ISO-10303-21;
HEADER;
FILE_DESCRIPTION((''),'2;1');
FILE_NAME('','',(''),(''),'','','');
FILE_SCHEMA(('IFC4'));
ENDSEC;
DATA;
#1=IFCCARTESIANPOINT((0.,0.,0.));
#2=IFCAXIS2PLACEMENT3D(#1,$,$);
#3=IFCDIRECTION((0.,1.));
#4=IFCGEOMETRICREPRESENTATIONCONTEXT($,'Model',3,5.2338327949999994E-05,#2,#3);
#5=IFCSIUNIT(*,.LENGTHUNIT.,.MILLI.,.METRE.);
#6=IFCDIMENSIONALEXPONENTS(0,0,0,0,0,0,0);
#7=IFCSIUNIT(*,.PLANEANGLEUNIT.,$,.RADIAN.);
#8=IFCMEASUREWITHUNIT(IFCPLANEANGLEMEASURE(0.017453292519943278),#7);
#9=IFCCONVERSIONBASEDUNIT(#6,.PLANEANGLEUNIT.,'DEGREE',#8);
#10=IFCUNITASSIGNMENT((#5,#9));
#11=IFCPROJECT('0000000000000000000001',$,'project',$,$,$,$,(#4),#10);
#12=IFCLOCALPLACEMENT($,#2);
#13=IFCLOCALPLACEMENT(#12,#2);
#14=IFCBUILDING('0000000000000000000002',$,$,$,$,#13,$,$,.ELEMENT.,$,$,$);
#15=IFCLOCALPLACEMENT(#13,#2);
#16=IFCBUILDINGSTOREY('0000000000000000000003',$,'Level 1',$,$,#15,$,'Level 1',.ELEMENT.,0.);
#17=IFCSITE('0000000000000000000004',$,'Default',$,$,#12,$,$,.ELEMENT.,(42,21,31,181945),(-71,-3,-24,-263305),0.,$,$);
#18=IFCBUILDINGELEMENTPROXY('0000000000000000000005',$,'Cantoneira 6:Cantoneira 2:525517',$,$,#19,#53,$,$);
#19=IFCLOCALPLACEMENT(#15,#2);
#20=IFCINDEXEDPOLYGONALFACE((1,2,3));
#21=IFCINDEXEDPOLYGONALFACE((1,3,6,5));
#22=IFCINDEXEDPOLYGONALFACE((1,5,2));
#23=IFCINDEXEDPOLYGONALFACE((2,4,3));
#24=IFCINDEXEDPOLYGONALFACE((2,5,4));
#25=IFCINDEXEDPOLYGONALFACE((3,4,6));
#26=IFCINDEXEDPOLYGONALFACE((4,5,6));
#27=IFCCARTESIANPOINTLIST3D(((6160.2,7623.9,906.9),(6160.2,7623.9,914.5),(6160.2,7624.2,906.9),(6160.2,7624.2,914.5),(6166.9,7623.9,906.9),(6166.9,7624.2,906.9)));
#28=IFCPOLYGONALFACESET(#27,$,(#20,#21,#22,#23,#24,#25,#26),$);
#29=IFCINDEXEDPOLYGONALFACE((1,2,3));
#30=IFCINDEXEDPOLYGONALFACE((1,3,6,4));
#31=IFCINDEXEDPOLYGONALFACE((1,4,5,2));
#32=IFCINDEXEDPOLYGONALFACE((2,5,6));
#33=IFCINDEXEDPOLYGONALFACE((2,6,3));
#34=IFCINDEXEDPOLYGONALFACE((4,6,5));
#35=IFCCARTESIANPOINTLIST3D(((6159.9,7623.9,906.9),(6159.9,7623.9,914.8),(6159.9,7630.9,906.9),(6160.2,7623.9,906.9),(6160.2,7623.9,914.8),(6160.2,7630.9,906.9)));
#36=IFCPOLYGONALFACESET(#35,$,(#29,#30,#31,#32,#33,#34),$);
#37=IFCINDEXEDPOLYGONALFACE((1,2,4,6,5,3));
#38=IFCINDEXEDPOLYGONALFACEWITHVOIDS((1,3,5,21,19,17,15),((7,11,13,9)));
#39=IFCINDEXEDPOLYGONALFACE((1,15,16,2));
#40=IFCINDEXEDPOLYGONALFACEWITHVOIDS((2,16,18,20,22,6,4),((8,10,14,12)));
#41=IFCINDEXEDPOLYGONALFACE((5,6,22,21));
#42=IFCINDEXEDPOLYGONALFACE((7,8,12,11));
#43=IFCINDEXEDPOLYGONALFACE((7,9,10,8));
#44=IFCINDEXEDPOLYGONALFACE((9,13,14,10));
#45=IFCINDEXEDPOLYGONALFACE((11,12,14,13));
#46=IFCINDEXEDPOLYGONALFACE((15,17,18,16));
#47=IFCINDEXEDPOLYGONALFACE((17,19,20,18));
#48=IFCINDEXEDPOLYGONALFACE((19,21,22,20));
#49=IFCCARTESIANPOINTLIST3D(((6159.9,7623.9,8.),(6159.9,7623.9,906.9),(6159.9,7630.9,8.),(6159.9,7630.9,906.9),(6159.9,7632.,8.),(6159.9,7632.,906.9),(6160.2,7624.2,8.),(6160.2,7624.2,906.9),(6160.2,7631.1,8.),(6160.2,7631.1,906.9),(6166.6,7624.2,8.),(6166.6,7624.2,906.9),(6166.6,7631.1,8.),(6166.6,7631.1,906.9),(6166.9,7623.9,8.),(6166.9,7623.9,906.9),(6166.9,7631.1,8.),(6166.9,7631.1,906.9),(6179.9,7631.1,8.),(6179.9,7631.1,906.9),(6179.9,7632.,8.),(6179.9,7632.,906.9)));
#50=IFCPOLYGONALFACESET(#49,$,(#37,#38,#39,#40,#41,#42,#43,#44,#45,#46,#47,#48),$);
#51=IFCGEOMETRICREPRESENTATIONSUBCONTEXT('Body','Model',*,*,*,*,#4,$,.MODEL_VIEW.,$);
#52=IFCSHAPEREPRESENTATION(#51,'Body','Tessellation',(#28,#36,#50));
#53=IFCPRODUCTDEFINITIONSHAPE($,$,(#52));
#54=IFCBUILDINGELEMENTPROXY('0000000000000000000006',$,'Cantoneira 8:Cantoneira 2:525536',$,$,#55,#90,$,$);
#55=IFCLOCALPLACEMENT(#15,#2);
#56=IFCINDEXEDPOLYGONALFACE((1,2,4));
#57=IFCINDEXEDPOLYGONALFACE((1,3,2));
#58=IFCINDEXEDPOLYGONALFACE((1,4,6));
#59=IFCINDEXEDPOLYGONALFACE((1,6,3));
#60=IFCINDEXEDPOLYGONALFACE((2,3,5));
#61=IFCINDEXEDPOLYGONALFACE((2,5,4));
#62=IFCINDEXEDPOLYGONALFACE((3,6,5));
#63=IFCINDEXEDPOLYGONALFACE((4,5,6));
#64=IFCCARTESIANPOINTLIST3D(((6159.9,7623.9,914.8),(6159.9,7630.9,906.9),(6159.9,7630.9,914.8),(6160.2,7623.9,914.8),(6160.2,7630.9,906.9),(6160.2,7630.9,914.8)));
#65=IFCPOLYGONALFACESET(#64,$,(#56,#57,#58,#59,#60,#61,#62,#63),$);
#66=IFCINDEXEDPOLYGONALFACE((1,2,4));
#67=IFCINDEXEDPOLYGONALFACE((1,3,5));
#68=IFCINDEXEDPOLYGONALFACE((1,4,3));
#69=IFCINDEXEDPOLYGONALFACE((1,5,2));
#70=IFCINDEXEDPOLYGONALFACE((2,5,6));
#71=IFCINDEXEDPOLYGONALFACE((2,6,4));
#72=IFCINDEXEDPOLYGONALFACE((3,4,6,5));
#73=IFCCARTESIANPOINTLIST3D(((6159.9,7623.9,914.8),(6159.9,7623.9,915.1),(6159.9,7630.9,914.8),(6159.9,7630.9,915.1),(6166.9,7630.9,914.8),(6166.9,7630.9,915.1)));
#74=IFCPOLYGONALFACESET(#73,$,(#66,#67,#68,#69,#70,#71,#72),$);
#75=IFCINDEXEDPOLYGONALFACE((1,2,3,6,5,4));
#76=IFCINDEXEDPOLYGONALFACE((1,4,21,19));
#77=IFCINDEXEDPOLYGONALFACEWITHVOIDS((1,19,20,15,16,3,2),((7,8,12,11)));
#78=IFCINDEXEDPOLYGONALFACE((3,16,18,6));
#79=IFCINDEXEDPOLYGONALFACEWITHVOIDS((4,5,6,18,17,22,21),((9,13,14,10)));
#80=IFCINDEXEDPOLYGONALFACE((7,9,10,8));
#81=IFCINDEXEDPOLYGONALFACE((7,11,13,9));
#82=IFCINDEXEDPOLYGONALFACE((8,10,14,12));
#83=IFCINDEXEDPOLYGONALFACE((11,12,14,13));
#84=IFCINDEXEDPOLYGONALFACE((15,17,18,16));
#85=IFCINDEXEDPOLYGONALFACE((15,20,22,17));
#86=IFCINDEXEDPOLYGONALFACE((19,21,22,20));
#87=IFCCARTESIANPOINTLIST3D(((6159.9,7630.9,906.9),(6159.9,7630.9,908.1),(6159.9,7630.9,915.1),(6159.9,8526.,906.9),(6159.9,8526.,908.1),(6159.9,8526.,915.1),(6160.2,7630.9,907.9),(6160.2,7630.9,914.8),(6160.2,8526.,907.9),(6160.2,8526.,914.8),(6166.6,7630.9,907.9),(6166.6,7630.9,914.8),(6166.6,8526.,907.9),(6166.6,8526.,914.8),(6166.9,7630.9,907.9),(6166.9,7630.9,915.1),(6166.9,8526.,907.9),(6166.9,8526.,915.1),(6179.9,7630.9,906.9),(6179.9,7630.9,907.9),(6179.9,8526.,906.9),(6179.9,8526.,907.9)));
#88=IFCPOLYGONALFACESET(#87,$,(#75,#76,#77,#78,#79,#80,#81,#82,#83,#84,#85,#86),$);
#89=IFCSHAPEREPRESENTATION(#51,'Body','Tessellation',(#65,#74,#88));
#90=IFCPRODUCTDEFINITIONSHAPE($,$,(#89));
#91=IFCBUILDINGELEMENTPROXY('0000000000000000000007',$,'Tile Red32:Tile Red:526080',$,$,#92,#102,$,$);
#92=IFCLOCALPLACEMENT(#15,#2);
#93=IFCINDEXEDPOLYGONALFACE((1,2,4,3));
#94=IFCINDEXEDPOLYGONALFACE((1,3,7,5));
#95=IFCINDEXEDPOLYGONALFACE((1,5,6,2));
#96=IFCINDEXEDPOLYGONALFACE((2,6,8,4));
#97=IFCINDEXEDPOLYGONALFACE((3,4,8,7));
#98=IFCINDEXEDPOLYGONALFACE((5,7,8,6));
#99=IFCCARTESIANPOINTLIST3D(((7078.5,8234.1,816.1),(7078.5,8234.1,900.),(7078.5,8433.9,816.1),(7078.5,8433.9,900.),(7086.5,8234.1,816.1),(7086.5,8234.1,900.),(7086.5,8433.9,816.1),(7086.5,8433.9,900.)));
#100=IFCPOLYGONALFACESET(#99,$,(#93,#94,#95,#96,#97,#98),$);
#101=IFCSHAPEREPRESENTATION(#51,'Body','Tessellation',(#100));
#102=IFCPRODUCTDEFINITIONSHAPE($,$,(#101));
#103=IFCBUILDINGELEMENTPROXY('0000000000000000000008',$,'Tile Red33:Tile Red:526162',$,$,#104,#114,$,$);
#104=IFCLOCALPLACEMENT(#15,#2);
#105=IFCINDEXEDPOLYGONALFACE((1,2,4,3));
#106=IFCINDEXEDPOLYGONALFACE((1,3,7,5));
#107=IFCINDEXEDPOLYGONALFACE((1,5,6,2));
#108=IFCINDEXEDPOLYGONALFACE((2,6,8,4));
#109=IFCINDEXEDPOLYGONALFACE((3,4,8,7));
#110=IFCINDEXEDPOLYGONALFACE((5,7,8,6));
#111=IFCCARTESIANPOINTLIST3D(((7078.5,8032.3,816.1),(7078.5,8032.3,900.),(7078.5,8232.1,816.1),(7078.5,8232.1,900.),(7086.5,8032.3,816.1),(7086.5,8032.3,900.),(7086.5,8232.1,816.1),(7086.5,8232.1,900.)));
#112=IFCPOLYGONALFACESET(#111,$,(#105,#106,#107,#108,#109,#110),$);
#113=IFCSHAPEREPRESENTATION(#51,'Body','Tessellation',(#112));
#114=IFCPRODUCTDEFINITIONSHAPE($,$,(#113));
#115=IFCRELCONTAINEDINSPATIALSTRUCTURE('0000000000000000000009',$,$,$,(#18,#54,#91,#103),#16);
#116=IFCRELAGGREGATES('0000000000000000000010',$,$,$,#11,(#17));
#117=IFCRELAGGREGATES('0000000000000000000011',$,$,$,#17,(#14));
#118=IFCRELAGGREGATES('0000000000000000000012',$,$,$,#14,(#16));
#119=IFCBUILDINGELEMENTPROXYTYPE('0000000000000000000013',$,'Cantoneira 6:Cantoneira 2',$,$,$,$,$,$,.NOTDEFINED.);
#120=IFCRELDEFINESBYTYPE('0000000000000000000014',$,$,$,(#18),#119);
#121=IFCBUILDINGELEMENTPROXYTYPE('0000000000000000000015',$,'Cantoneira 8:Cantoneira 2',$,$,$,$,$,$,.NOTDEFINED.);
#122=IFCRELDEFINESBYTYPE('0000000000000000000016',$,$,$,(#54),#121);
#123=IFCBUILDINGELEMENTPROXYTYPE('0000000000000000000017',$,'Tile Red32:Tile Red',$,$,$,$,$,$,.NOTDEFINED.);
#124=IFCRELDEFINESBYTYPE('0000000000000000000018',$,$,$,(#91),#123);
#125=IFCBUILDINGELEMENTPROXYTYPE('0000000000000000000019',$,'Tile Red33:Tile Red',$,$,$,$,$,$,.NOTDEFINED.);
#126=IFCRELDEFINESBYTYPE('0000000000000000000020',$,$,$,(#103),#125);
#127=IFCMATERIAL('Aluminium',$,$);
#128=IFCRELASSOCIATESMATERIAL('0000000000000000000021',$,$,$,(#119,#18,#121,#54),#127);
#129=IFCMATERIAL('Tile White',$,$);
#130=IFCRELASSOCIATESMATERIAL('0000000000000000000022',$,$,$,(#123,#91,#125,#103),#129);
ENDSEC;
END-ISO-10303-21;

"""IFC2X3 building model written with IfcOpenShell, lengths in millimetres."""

from ifc_helpers import new_model, entity, si_unit, converted_unit, direction, frame, frame_2d, origin, place, context, subcontext, project, spatial, polyline, rectangle, outline, extrude, source, transform, mapped, material, type_object, type_shapes, element, save


model = new_model("IFC2X3")

# Units and contexts
model_context = context("Model", 3, precision=5.2338327949999994e-05, world=origin(), true_north=direction((0.0, 1.0)))
body_context = subcontext(model_context, "Body", "Model", "MODEL_VIEW")
ifc_project = project(units=[si_unit("LENGTHUNIT", "METRE", prefix="MILLI"), converted_unit("PLANEANGLEUNIT", "DEGREE", entity("IfcPlaneAngleMeasure", 0.017453292519943278), si_unit("PLANEANGLEUNIT", "RADIAN"), dimensions=[0, 0, 0, 0, 0, 0, 0])], contexts=[model_context])

# Site, building, storey
site_placement = place(None, origin())
site = spatial("IfcSite", under=ifc_project, at=site_placement, Name="Default", CompositionType="ELEMENT", RefLatitude=(42, 21, 31, 181945), RefLongitude=(-71, -3, -24, -263305), RefElevation=0.0)
building_placement = place(site_placement, origin())
building = spatial("IfcBuilding", under=site, at=building_placement, CompositionType="ELEMENT")
storey_placement = place(building_placement, origin())
storey = spatial("IfcBuildingStorey", under=building, at=storey_placement, Name="Level 1", LongName="Level 1", CompositionType="ELEMENT", Elevation=0.0)

# Building element proxies
ifc_material_1 = material(Name="Aluminium")
ifc_material_2 = material(Name="Tile White")
building_element_proxy_type_1 = type_object("IfcBuildingElementProxyType", Name="Cantoneira 6:Cantoneira 2", PredefinedType="NOTDEFINED", material=ifc_material_1)
shared_shape_1 = source(origin(), body_context, "Body", "SweptSolid", [
    extrude(outline(polyline([(-2.5, -2.2), (5.0, -2.2), (-2.5, 4.5), (-2.5, -2.2)])), frame((6162.4, 7623.9, 909.4), z_axis=(0.0, 1.0, 0.0), x_axis=(0.0, 0.0, 1.0)), (0.0, 0.0, 1.0), 0.3),
    extrude(outline(polyline([(-5.1, -1.8), (5.5, -1.8), (-0.4, 3.5), (-5.1, -1.8)])), frame((6159.9, 7626.2, 909.6), z_axis=(1.0, 0.0, 0.0), x_axis=(0.0, -0.664803, 0.747019)), (0.0, 0.0, 1.0), 0.3),
    extrude(outline(polyline([(-1.6, -7.7), (5.4, -7.7), (5.4, -0.7), (-1.8, -0.7), (-1.8, 12.3), (-2.8, 12.3), (-2.8, -7.7), (-1.6, -7.7)]), holes=[polyline([(5.1, -1.0), (5.1, -7.4), (-1.8, -7.4), (-1.8, -1.0), (5.1, -1.0)])]), frame((6167.6, 7629.3, 8.0), z_axis=(0.0, 0.0, 1.0), x_axis=(0.0, -1.0, 0.0)), (0.0, 0.0, 1.0), 898.9),
])
type_shapes(building_element_proxy_type_1, [shared_shape_1])
proxy_1_placement = place(storey_placement, origin())
element("IfcBuildingElementProxy", 1, at=proxy_1_placement, inside=storey, type_object=building_element_proxy_type_1, material=ifc_material_1, Name="Cantoneira 6:Cantoneira 2:525517", context=body_context, shape_type="MappedRepresentation", body=[
    mapped(shared_shape_1, transform((0.0, 0.0, 0.0), scale=1.0)),
])
building_element_proxy_type_2 = type_object("IfcBuildingElementProxyType", Name="Cantoneira 8:Cantoneira 2", PredefinedType="NOTDEFINED", material=ifc_material_1)
shared_shape_2 = source(origin(), body_context, "Body", "SweptSolid", [
    extrude(outline(polyline([(-5.1, -1.7), (5.5, -1.7), (-0.4, 3.5), (-5.1, -1.7)])), frame((6159.9, 7628.5, 912.2), z_axis=(1.0, 0.0, 0.0), x_axis=(0.0, 0.664803, -0.747019)), (0.0, 0.0, 1.0), 0.3),
    extrude(outline(polyline([(-4.7, -2.3), (2.3, -2.3), (2.3, 4.7), (-4.7, -2.3)])), frame((6162.2, 7628.5, 914.8), z_axis=(0.0, 0.0, 1.0), x_axis=(-1.0, 0.0, 0.0)), (0.0, 0.0, 1.0), 0.3),
    extrude(outline(polyline([(-1.6, -7.7), (5.4, -7.7), (5.4, -0.7), (-1.8, -0.7), (-1.8, 12.3), (-2.8, 12.3), (-2.8, -7.7), (-1.6, -7.7)]), holes=[polyline([(5.1, -1.0), (5.1, -7.4), (-1.8, -7.4), (-1.8, -1.0), (5.1, -1.0)])]), frame((6167.6, 7630.9, 909.7), z_axis=(0.0, 1.0, 0.0), x_axis=(0.0, 0.0, 1.0)), (0.0, 0.0, 1.0), 895.1),
])
type_shapes(building_element_proxy_type_2, [shared_shape_2])
proxy_2_placement = place(storey_placement, origin())
element("IfcBuildingElementProxy", 2, at=proxy_2_placement, inside=storey, type_object=building_element_proxy_type_2, material=ifc_material_1, Name="Cantoneira 8:Cantoneira 2:525536", context=body_context, shape_type="MappedRepresentation", body=[
    mapped(shared_shape_2, transform((0.0, 0.0, 0.0), scale=1.0)),
])
building_element_proxy_type_3 = type_object("IfcBuildingElementProxyType", Name="Tile Red32:Tile Red", PredefinedType="NOTDEFINED", material=ifc_material_2)
shared_shape_3 = source(origin(), body_context, "Body", "SweptSolid", [
    extrude(rectangle(XDim=8.0, YDim=199.8, at=frame_2d((0.0, 0.0), x_axis=(1.0, 0.0))), frame((7082.5, 8334.0, 816.1)), (0.0, 0.0, 1.0), 83.9),
])
type_shapes(building_element_proxy_type_3, [shared_shape_3])
proxy_3_placement = place(storey_placement, origin())
element("IfcBuildingElementProxy", 3, at=proxy_3_placement, inside=storey, type_object=building_element_proxy_type_3, material=ifc_material_2, Name="Tile Red32:Tile Red:526080", context=body_context, shape_type="MappedRepresentation", body=[
    mapped(shared_shape_3, transform((0.0, 0.0, 0.0), scale=1.0)),
])
building_element_proxy_type_4 = type_object("IfcBuildingElementProxyType", Name="Tile Red33:Tile Red", PredefinedType="NOTDEFINED", material=ifc_material_2)
shared_shape_4 = source(origin(), body_context, "Body", "SweptSolid", [
    extrude(rectangle(XDim=8.0, YDim=199.8, at=frame_2d((0.0, 0.0), x_axis=(1.0, 0.0))), frame((7082.5, 8132.2, 816.1)), (0.0, 0.0, 1.0), 83.9),
])
type_shapes(building_element_proxy_type_4, [shared_shape_4])
proxy_4_placement = place(storey_placement, origin())
element("IfcBuildingElementProxy", 4, at=proxy_4_placement, inside=storey, type_object=building_element_proxy_type_4, material=ifc_material_2, Name="Tile Red33:Tile Red:526162", context=body_context, shape_type="MappedRepresentation", body=[
    mapped(shared_shape_4, transform((0.0, 0.0, 0.0), scale=1.0)),
])

save(model, "model.ifc")
